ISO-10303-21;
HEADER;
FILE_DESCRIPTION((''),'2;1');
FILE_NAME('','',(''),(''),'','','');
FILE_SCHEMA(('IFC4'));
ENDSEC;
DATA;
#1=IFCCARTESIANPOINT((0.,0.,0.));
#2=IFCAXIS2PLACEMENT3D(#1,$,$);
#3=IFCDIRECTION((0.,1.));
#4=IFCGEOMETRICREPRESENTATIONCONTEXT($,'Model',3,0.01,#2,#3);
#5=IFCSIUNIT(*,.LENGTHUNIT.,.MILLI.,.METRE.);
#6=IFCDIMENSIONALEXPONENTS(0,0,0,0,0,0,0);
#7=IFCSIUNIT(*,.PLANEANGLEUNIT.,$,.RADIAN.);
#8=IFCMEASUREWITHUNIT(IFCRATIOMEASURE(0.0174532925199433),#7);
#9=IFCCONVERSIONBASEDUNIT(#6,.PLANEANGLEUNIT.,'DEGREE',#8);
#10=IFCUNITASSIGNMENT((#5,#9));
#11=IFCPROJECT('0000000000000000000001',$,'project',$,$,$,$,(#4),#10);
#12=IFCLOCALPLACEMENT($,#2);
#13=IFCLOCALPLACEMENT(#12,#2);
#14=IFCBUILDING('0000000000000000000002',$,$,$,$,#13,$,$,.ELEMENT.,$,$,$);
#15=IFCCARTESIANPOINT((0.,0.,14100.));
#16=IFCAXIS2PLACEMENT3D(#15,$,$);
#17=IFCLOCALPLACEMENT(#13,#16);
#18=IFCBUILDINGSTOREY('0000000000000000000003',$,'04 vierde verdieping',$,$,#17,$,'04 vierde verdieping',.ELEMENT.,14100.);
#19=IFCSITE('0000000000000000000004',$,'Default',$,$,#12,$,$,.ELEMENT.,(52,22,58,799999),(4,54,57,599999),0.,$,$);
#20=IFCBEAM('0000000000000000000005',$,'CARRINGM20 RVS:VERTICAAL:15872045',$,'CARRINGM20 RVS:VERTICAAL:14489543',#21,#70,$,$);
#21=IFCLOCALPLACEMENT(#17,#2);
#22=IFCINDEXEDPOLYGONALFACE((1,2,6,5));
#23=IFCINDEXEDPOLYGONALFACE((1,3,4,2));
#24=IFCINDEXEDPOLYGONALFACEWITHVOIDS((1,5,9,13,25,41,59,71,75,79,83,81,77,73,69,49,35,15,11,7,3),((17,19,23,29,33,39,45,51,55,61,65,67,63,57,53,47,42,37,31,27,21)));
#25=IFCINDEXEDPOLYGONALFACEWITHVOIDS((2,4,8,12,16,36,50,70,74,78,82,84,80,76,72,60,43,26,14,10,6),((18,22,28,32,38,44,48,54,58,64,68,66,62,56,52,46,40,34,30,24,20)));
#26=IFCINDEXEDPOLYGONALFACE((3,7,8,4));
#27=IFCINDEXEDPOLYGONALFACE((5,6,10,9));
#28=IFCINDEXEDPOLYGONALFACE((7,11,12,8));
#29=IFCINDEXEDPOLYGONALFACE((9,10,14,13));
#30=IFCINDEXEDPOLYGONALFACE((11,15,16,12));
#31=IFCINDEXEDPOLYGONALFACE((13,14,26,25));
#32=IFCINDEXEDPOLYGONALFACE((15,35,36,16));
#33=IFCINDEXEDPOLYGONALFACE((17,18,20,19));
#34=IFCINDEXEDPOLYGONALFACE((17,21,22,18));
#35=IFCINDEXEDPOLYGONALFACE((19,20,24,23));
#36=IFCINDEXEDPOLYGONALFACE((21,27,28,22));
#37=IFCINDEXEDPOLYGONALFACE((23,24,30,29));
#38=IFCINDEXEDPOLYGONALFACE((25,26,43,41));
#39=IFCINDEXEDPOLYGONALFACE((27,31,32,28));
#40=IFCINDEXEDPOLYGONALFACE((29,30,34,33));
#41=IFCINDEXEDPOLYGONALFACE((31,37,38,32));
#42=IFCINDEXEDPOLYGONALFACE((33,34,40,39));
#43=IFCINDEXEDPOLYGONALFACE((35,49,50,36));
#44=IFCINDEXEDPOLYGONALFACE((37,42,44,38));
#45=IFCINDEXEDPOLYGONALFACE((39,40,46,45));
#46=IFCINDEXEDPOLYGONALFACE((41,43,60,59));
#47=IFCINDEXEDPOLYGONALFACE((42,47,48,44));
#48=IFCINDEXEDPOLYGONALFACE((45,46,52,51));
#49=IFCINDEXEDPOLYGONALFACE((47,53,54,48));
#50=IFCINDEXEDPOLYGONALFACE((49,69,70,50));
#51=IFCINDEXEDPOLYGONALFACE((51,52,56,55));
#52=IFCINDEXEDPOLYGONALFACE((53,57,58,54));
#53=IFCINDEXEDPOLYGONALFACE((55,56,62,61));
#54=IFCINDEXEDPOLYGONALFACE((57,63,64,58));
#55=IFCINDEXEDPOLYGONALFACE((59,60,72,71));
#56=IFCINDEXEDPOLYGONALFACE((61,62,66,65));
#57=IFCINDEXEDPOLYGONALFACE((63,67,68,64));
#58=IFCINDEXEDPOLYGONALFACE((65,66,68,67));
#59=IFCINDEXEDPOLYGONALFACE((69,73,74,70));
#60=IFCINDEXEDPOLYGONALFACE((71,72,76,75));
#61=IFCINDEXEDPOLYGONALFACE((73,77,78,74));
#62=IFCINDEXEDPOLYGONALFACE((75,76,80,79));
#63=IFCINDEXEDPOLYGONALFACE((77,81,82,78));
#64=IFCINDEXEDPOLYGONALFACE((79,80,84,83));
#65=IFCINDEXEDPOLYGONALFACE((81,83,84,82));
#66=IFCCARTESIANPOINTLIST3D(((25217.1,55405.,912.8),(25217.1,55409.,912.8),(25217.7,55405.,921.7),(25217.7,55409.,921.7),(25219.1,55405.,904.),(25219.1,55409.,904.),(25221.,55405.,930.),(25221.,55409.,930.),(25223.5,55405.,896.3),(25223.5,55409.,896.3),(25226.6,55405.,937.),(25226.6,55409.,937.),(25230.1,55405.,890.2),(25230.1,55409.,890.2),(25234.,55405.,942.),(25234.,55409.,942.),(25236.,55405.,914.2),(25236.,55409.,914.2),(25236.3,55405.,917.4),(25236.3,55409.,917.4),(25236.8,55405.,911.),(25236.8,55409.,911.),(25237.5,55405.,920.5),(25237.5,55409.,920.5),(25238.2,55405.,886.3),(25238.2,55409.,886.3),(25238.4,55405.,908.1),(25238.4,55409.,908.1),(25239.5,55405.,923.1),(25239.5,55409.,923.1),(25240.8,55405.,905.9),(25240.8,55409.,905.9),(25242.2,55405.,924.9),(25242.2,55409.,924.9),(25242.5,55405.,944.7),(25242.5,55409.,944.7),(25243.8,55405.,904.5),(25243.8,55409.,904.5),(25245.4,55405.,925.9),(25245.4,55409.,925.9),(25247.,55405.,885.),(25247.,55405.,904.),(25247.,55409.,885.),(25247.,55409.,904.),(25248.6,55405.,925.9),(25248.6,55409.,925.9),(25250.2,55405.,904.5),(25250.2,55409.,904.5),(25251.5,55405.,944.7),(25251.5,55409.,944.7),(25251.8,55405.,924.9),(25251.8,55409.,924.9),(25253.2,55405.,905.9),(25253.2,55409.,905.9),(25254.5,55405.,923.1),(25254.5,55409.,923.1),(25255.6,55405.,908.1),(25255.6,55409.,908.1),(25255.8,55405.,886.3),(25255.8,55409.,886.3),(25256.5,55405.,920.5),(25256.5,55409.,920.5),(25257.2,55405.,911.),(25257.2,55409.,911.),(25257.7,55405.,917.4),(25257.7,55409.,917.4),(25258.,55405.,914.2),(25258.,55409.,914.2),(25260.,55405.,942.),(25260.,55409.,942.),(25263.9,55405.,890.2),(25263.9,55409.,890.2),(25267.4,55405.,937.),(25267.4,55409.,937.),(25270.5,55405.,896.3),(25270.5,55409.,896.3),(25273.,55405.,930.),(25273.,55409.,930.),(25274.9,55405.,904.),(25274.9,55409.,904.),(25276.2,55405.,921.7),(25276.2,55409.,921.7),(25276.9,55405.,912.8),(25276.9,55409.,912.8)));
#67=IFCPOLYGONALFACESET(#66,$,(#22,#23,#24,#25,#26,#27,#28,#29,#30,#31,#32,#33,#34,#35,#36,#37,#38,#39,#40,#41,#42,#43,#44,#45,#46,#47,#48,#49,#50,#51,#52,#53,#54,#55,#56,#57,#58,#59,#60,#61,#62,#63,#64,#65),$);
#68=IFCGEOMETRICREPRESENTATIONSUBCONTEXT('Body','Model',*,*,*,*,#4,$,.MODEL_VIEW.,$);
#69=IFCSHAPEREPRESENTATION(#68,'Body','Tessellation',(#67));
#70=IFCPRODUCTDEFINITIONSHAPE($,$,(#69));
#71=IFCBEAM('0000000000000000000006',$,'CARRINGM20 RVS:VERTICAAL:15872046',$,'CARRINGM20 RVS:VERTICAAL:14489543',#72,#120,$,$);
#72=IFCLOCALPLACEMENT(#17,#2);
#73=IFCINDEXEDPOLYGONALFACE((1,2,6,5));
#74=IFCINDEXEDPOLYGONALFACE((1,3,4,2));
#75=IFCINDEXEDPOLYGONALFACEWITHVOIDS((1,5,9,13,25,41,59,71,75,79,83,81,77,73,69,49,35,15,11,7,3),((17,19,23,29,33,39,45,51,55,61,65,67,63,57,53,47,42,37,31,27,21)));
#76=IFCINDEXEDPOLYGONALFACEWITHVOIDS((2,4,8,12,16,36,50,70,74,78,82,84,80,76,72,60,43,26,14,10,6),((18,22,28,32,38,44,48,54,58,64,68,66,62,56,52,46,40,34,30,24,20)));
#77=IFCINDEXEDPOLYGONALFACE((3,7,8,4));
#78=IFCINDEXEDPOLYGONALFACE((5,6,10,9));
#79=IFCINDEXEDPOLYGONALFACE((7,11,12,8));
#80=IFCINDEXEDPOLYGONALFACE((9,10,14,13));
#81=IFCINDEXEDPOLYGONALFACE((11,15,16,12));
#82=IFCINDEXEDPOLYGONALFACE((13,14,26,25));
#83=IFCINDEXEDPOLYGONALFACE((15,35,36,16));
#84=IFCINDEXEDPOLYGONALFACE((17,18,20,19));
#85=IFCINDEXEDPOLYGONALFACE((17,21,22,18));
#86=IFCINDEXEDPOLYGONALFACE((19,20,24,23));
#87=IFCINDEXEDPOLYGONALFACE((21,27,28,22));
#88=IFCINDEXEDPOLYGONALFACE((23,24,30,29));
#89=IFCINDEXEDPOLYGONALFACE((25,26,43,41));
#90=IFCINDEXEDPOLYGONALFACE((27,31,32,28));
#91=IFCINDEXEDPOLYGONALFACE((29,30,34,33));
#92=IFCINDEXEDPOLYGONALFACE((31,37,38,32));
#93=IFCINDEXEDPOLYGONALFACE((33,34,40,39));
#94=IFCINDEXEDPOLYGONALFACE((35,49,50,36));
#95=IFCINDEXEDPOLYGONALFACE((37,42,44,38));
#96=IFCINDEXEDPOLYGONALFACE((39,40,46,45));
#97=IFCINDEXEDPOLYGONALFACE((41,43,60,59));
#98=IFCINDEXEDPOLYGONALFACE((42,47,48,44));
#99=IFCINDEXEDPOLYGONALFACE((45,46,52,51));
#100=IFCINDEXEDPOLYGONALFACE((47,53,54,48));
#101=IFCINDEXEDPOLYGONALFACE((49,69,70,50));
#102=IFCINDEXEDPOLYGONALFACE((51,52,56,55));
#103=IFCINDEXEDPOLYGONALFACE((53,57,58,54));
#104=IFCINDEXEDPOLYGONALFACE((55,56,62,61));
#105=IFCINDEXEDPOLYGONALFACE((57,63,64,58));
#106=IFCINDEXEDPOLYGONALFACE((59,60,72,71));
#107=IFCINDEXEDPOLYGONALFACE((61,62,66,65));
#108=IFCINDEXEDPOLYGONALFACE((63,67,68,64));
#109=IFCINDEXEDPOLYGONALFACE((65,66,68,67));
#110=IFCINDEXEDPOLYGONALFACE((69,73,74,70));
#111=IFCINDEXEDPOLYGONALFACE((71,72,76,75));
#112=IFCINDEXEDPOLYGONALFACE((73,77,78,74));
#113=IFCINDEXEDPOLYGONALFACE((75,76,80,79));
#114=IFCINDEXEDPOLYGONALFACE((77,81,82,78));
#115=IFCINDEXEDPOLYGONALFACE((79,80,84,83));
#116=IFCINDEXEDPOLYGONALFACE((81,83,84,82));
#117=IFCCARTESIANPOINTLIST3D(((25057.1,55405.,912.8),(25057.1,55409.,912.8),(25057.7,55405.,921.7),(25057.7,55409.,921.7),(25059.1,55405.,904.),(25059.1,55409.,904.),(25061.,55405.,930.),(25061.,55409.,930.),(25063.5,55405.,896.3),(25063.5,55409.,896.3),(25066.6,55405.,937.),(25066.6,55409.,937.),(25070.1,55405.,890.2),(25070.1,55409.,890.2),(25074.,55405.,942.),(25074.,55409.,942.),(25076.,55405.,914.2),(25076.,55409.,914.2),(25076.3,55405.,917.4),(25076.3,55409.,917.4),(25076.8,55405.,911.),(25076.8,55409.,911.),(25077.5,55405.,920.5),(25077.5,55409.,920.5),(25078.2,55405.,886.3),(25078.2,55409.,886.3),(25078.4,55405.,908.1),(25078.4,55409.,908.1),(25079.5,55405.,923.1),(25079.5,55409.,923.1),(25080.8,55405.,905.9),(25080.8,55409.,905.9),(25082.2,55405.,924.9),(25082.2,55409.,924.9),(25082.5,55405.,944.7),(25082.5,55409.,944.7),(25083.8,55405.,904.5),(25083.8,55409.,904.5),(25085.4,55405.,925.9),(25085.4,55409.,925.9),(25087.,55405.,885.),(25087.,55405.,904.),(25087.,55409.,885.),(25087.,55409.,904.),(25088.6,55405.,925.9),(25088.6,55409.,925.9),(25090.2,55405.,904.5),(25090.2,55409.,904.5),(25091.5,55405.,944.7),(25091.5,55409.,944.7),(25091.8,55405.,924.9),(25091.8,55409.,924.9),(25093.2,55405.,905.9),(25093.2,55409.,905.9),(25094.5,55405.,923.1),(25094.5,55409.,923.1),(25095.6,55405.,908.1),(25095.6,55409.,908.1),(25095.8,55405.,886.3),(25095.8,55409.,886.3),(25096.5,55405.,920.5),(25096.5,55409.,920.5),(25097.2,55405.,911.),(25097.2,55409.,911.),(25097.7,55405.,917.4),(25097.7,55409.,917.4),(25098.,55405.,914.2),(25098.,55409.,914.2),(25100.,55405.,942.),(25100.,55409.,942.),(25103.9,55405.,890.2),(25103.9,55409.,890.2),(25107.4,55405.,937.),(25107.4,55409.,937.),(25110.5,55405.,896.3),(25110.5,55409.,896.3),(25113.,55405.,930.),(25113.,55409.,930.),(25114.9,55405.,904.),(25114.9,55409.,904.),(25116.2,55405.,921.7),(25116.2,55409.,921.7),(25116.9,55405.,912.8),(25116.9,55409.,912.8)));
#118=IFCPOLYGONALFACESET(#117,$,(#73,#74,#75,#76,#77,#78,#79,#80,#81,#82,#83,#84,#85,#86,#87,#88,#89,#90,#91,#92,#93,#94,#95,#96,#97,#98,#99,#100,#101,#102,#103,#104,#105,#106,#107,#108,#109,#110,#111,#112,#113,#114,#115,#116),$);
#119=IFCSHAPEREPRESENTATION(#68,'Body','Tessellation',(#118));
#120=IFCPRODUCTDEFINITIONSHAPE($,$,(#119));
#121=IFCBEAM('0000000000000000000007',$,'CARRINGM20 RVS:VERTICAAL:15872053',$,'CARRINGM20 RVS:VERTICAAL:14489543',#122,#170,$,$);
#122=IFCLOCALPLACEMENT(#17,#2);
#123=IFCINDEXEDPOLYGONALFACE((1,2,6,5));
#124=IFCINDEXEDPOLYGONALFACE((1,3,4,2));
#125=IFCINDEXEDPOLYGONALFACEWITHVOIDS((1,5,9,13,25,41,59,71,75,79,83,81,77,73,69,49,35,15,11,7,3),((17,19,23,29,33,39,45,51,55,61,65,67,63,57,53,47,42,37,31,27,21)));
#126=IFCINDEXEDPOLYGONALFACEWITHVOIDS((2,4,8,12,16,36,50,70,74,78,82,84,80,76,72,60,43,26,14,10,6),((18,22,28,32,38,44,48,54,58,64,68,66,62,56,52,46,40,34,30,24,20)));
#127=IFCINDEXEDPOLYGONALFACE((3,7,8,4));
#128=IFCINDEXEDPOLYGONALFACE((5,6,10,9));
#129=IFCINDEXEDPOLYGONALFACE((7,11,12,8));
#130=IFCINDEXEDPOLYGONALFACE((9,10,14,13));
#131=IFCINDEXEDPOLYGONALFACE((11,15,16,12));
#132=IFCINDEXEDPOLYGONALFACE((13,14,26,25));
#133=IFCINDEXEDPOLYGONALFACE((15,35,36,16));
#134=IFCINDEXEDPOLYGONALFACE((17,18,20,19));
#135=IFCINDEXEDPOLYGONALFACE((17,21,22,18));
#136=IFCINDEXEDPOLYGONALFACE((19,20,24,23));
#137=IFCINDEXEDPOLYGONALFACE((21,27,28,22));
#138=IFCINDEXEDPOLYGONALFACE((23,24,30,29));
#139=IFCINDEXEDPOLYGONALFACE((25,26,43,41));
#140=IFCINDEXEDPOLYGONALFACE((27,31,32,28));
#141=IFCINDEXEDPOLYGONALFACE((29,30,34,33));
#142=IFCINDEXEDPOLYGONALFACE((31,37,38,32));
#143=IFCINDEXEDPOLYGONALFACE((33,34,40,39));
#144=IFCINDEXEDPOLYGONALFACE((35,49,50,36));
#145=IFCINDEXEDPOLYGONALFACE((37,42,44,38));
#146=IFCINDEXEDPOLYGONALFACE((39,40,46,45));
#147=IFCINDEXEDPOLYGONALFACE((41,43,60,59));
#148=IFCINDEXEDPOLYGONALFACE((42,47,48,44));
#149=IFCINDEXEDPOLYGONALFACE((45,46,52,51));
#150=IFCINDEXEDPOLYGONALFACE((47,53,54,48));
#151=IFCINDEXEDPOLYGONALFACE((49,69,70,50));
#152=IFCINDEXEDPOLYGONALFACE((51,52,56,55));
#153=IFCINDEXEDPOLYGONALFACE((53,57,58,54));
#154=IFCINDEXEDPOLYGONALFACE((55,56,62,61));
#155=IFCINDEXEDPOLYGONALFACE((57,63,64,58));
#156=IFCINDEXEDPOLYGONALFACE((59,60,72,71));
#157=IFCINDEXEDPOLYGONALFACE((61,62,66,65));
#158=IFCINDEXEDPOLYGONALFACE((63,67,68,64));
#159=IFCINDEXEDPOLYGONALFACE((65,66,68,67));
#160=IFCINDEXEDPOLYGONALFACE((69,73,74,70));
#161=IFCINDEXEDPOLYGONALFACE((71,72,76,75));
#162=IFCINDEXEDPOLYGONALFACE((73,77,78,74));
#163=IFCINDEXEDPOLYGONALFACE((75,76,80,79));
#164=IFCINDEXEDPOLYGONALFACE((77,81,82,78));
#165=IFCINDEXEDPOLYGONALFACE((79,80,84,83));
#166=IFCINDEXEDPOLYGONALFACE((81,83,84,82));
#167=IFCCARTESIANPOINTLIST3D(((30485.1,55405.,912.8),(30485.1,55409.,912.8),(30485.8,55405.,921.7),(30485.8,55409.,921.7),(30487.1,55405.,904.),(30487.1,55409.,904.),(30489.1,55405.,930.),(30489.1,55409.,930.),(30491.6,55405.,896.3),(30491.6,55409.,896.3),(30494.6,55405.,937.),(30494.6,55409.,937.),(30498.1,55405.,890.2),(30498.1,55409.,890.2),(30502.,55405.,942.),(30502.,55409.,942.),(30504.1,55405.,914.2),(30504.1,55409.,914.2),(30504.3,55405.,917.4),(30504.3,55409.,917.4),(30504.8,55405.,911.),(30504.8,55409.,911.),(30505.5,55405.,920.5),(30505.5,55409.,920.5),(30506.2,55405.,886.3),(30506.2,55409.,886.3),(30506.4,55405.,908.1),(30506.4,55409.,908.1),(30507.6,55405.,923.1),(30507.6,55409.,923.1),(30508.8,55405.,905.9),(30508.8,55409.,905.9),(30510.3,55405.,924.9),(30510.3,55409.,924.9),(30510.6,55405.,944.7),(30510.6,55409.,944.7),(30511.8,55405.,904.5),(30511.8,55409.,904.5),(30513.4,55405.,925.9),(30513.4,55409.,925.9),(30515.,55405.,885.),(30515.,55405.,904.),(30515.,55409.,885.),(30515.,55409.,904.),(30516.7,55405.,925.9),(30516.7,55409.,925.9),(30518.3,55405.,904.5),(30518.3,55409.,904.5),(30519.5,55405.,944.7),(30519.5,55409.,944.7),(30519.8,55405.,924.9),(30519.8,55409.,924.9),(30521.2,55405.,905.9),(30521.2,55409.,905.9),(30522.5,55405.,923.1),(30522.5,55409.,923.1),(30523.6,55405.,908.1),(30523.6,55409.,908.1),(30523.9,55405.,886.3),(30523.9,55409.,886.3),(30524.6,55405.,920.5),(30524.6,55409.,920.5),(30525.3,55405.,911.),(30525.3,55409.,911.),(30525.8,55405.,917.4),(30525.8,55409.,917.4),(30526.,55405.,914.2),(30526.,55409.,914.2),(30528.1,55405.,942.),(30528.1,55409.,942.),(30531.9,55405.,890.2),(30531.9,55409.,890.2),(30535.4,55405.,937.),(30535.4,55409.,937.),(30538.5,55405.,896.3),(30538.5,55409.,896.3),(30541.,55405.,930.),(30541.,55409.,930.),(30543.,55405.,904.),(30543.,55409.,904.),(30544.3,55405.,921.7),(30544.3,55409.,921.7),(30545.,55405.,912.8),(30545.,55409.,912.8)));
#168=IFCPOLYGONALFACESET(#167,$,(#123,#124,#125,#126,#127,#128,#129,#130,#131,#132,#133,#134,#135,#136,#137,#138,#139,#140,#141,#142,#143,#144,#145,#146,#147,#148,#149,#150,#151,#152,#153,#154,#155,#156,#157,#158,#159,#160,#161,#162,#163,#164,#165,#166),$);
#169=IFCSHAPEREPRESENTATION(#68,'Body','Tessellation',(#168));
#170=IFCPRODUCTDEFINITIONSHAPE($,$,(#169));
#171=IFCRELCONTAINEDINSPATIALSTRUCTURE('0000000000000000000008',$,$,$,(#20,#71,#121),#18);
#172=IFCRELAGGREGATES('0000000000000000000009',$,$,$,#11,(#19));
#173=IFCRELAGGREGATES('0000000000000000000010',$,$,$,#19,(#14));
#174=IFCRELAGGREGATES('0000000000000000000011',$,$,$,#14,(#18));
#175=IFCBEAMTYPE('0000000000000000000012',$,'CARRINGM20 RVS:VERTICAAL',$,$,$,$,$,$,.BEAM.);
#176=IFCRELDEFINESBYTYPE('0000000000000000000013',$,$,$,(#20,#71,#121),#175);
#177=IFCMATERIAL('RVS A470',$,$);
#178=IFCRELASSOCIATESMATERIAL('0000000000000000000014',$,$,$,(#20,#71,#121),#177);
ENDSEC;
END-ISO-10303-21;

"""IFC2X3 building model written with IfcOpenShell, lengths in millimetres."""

from ifc_helpers import new_model, entity, si_unit, converted_unit, direction, frame, origin, origin_2d_with_axis, place, context, subcontext, project, spatial, hollow_circle, extrude, material, type_object, element, save


model = new_model("IFC2X3")

# Units and contexts
model_context = context("Model", 3, precision=0.01, world=origin(), true_north=direction((0.0, 1.0)))
body_context = subcontext(model_context, "Body", "Model", "MODEL_VIEW")
ifc_project = project(units=[si_unit("LENGTHUNIT", "METRE", prefix="MILLI"), converted_unit("PLANEANGLEUNIT", "DEGREE", entity("IfcRatioMeasure", 0.0174532925199433), si_unit("PLANEANGLEUNIT", "RADIAN"), dimensions=[0, 0, 0, 0, 0, 0, 0])], contexts=[model_context])

# Site, building, storey
site_placement = place(None, origin())
site = spatial("IfcSite", under=ifc_project, at=site_placement, Name="Default", CompositionType="ELEMENT", RefLatitude=(52, 22, 58, 799999), RefLongitude=(4, 54, 57, 599999), RefElevation=0.0)
building_placement = place(site_placement, origin())
building = spatial("IfcBuilding", under=site, at=building_placement, CompositionType="ELEMENT")
storey_placement = place(building_placement, frame((0.0, 0.0, 14100.0)))
storey = spatial("IfcBuildingStorey", under=building, at=storey_placement, Name="04 vierde verdieping", LongName="04 vierde verdieping", CompositionType="ELEMENT", Elevation=14100.0)

# Beams
ifc_material_1 = material(Name="RVS A470")
beam_type_1 = type_object("IfcBeamType", Name="CARRINGM20 RVS:VERTICAAL", PredefinedType="BEAM")
beam_1_placement = place(storey_placement, origin())
element("IfcBeam", 1, at=beam_1_placement, inside=storey, type_object=beam_type_1, material=ifc_material_1, Name="CARRINGM20 RVS:VERTICAAL:15872045", ObjectType="CARRINGM20 RVS:VERTICAAL:14489543", context=body_context, shape_type="SweptSolid", body=[
    extrude(hollow_circle(Radius=30.0, WallThickness=19.0, at=origin_2d_with_axis()), frame((25247.0, 55405.0, 915.0), z_axis=(0.0, 1.0, 0.0), x_axis=(0.0, 0.0, -1.0)), (0.0, 0.0, 1.0), 4.0),
])
beam_2_placement = place(storey_placement, origin())
element("IfcBeam", 2, at=beam_2_placement, inside=storey, type_object=beam_type_1, material=ifc_material_1, Name="CARRINGM20 RVS:VERTICAAL:15872046", ObjectType="CARRINGM20 RVS:VERTICAAL:14489543", context=body_context, shape_type="SweptSolid", body=[
    extrude(hollow_circle(Radius=30.0, WallThickness=19.0, at=origin_2d_with_axis()), frame((25087.0, 55405.0, 915.0), z_axis=(0.0, 1.0, 0.0), x_axis=(0.0, 0.0, -1.0)), (0.0, 0.0, 1.0), 4.0),
])
beam_3_placement = place(storey_placement, origin())
element("IfcBeam", 3, at=beam_3_placement, inside=storey, type_object=beam_type_1, material=ifc_material_1, Name="CARRINGM20 RVS:VERTICAAL:15872053", ObjectType="CARRINGM20 RVS:VERTICAAL:14489543", context=body_context, shape_type="SweptSolid", body=[
    extrude(hollow_circle(Radius=30.0, WallThickness=19.0, at=origin_2d_with_axis()), frame((30515.0, 55405.0, 915.0), z_axis=(0.0, 1.0, 0.0), x_axis=(0.0, 0.0, -1.0)), (0.0, 0.0, 1.0), 4.0),
])

save(model, "model.ifc")
